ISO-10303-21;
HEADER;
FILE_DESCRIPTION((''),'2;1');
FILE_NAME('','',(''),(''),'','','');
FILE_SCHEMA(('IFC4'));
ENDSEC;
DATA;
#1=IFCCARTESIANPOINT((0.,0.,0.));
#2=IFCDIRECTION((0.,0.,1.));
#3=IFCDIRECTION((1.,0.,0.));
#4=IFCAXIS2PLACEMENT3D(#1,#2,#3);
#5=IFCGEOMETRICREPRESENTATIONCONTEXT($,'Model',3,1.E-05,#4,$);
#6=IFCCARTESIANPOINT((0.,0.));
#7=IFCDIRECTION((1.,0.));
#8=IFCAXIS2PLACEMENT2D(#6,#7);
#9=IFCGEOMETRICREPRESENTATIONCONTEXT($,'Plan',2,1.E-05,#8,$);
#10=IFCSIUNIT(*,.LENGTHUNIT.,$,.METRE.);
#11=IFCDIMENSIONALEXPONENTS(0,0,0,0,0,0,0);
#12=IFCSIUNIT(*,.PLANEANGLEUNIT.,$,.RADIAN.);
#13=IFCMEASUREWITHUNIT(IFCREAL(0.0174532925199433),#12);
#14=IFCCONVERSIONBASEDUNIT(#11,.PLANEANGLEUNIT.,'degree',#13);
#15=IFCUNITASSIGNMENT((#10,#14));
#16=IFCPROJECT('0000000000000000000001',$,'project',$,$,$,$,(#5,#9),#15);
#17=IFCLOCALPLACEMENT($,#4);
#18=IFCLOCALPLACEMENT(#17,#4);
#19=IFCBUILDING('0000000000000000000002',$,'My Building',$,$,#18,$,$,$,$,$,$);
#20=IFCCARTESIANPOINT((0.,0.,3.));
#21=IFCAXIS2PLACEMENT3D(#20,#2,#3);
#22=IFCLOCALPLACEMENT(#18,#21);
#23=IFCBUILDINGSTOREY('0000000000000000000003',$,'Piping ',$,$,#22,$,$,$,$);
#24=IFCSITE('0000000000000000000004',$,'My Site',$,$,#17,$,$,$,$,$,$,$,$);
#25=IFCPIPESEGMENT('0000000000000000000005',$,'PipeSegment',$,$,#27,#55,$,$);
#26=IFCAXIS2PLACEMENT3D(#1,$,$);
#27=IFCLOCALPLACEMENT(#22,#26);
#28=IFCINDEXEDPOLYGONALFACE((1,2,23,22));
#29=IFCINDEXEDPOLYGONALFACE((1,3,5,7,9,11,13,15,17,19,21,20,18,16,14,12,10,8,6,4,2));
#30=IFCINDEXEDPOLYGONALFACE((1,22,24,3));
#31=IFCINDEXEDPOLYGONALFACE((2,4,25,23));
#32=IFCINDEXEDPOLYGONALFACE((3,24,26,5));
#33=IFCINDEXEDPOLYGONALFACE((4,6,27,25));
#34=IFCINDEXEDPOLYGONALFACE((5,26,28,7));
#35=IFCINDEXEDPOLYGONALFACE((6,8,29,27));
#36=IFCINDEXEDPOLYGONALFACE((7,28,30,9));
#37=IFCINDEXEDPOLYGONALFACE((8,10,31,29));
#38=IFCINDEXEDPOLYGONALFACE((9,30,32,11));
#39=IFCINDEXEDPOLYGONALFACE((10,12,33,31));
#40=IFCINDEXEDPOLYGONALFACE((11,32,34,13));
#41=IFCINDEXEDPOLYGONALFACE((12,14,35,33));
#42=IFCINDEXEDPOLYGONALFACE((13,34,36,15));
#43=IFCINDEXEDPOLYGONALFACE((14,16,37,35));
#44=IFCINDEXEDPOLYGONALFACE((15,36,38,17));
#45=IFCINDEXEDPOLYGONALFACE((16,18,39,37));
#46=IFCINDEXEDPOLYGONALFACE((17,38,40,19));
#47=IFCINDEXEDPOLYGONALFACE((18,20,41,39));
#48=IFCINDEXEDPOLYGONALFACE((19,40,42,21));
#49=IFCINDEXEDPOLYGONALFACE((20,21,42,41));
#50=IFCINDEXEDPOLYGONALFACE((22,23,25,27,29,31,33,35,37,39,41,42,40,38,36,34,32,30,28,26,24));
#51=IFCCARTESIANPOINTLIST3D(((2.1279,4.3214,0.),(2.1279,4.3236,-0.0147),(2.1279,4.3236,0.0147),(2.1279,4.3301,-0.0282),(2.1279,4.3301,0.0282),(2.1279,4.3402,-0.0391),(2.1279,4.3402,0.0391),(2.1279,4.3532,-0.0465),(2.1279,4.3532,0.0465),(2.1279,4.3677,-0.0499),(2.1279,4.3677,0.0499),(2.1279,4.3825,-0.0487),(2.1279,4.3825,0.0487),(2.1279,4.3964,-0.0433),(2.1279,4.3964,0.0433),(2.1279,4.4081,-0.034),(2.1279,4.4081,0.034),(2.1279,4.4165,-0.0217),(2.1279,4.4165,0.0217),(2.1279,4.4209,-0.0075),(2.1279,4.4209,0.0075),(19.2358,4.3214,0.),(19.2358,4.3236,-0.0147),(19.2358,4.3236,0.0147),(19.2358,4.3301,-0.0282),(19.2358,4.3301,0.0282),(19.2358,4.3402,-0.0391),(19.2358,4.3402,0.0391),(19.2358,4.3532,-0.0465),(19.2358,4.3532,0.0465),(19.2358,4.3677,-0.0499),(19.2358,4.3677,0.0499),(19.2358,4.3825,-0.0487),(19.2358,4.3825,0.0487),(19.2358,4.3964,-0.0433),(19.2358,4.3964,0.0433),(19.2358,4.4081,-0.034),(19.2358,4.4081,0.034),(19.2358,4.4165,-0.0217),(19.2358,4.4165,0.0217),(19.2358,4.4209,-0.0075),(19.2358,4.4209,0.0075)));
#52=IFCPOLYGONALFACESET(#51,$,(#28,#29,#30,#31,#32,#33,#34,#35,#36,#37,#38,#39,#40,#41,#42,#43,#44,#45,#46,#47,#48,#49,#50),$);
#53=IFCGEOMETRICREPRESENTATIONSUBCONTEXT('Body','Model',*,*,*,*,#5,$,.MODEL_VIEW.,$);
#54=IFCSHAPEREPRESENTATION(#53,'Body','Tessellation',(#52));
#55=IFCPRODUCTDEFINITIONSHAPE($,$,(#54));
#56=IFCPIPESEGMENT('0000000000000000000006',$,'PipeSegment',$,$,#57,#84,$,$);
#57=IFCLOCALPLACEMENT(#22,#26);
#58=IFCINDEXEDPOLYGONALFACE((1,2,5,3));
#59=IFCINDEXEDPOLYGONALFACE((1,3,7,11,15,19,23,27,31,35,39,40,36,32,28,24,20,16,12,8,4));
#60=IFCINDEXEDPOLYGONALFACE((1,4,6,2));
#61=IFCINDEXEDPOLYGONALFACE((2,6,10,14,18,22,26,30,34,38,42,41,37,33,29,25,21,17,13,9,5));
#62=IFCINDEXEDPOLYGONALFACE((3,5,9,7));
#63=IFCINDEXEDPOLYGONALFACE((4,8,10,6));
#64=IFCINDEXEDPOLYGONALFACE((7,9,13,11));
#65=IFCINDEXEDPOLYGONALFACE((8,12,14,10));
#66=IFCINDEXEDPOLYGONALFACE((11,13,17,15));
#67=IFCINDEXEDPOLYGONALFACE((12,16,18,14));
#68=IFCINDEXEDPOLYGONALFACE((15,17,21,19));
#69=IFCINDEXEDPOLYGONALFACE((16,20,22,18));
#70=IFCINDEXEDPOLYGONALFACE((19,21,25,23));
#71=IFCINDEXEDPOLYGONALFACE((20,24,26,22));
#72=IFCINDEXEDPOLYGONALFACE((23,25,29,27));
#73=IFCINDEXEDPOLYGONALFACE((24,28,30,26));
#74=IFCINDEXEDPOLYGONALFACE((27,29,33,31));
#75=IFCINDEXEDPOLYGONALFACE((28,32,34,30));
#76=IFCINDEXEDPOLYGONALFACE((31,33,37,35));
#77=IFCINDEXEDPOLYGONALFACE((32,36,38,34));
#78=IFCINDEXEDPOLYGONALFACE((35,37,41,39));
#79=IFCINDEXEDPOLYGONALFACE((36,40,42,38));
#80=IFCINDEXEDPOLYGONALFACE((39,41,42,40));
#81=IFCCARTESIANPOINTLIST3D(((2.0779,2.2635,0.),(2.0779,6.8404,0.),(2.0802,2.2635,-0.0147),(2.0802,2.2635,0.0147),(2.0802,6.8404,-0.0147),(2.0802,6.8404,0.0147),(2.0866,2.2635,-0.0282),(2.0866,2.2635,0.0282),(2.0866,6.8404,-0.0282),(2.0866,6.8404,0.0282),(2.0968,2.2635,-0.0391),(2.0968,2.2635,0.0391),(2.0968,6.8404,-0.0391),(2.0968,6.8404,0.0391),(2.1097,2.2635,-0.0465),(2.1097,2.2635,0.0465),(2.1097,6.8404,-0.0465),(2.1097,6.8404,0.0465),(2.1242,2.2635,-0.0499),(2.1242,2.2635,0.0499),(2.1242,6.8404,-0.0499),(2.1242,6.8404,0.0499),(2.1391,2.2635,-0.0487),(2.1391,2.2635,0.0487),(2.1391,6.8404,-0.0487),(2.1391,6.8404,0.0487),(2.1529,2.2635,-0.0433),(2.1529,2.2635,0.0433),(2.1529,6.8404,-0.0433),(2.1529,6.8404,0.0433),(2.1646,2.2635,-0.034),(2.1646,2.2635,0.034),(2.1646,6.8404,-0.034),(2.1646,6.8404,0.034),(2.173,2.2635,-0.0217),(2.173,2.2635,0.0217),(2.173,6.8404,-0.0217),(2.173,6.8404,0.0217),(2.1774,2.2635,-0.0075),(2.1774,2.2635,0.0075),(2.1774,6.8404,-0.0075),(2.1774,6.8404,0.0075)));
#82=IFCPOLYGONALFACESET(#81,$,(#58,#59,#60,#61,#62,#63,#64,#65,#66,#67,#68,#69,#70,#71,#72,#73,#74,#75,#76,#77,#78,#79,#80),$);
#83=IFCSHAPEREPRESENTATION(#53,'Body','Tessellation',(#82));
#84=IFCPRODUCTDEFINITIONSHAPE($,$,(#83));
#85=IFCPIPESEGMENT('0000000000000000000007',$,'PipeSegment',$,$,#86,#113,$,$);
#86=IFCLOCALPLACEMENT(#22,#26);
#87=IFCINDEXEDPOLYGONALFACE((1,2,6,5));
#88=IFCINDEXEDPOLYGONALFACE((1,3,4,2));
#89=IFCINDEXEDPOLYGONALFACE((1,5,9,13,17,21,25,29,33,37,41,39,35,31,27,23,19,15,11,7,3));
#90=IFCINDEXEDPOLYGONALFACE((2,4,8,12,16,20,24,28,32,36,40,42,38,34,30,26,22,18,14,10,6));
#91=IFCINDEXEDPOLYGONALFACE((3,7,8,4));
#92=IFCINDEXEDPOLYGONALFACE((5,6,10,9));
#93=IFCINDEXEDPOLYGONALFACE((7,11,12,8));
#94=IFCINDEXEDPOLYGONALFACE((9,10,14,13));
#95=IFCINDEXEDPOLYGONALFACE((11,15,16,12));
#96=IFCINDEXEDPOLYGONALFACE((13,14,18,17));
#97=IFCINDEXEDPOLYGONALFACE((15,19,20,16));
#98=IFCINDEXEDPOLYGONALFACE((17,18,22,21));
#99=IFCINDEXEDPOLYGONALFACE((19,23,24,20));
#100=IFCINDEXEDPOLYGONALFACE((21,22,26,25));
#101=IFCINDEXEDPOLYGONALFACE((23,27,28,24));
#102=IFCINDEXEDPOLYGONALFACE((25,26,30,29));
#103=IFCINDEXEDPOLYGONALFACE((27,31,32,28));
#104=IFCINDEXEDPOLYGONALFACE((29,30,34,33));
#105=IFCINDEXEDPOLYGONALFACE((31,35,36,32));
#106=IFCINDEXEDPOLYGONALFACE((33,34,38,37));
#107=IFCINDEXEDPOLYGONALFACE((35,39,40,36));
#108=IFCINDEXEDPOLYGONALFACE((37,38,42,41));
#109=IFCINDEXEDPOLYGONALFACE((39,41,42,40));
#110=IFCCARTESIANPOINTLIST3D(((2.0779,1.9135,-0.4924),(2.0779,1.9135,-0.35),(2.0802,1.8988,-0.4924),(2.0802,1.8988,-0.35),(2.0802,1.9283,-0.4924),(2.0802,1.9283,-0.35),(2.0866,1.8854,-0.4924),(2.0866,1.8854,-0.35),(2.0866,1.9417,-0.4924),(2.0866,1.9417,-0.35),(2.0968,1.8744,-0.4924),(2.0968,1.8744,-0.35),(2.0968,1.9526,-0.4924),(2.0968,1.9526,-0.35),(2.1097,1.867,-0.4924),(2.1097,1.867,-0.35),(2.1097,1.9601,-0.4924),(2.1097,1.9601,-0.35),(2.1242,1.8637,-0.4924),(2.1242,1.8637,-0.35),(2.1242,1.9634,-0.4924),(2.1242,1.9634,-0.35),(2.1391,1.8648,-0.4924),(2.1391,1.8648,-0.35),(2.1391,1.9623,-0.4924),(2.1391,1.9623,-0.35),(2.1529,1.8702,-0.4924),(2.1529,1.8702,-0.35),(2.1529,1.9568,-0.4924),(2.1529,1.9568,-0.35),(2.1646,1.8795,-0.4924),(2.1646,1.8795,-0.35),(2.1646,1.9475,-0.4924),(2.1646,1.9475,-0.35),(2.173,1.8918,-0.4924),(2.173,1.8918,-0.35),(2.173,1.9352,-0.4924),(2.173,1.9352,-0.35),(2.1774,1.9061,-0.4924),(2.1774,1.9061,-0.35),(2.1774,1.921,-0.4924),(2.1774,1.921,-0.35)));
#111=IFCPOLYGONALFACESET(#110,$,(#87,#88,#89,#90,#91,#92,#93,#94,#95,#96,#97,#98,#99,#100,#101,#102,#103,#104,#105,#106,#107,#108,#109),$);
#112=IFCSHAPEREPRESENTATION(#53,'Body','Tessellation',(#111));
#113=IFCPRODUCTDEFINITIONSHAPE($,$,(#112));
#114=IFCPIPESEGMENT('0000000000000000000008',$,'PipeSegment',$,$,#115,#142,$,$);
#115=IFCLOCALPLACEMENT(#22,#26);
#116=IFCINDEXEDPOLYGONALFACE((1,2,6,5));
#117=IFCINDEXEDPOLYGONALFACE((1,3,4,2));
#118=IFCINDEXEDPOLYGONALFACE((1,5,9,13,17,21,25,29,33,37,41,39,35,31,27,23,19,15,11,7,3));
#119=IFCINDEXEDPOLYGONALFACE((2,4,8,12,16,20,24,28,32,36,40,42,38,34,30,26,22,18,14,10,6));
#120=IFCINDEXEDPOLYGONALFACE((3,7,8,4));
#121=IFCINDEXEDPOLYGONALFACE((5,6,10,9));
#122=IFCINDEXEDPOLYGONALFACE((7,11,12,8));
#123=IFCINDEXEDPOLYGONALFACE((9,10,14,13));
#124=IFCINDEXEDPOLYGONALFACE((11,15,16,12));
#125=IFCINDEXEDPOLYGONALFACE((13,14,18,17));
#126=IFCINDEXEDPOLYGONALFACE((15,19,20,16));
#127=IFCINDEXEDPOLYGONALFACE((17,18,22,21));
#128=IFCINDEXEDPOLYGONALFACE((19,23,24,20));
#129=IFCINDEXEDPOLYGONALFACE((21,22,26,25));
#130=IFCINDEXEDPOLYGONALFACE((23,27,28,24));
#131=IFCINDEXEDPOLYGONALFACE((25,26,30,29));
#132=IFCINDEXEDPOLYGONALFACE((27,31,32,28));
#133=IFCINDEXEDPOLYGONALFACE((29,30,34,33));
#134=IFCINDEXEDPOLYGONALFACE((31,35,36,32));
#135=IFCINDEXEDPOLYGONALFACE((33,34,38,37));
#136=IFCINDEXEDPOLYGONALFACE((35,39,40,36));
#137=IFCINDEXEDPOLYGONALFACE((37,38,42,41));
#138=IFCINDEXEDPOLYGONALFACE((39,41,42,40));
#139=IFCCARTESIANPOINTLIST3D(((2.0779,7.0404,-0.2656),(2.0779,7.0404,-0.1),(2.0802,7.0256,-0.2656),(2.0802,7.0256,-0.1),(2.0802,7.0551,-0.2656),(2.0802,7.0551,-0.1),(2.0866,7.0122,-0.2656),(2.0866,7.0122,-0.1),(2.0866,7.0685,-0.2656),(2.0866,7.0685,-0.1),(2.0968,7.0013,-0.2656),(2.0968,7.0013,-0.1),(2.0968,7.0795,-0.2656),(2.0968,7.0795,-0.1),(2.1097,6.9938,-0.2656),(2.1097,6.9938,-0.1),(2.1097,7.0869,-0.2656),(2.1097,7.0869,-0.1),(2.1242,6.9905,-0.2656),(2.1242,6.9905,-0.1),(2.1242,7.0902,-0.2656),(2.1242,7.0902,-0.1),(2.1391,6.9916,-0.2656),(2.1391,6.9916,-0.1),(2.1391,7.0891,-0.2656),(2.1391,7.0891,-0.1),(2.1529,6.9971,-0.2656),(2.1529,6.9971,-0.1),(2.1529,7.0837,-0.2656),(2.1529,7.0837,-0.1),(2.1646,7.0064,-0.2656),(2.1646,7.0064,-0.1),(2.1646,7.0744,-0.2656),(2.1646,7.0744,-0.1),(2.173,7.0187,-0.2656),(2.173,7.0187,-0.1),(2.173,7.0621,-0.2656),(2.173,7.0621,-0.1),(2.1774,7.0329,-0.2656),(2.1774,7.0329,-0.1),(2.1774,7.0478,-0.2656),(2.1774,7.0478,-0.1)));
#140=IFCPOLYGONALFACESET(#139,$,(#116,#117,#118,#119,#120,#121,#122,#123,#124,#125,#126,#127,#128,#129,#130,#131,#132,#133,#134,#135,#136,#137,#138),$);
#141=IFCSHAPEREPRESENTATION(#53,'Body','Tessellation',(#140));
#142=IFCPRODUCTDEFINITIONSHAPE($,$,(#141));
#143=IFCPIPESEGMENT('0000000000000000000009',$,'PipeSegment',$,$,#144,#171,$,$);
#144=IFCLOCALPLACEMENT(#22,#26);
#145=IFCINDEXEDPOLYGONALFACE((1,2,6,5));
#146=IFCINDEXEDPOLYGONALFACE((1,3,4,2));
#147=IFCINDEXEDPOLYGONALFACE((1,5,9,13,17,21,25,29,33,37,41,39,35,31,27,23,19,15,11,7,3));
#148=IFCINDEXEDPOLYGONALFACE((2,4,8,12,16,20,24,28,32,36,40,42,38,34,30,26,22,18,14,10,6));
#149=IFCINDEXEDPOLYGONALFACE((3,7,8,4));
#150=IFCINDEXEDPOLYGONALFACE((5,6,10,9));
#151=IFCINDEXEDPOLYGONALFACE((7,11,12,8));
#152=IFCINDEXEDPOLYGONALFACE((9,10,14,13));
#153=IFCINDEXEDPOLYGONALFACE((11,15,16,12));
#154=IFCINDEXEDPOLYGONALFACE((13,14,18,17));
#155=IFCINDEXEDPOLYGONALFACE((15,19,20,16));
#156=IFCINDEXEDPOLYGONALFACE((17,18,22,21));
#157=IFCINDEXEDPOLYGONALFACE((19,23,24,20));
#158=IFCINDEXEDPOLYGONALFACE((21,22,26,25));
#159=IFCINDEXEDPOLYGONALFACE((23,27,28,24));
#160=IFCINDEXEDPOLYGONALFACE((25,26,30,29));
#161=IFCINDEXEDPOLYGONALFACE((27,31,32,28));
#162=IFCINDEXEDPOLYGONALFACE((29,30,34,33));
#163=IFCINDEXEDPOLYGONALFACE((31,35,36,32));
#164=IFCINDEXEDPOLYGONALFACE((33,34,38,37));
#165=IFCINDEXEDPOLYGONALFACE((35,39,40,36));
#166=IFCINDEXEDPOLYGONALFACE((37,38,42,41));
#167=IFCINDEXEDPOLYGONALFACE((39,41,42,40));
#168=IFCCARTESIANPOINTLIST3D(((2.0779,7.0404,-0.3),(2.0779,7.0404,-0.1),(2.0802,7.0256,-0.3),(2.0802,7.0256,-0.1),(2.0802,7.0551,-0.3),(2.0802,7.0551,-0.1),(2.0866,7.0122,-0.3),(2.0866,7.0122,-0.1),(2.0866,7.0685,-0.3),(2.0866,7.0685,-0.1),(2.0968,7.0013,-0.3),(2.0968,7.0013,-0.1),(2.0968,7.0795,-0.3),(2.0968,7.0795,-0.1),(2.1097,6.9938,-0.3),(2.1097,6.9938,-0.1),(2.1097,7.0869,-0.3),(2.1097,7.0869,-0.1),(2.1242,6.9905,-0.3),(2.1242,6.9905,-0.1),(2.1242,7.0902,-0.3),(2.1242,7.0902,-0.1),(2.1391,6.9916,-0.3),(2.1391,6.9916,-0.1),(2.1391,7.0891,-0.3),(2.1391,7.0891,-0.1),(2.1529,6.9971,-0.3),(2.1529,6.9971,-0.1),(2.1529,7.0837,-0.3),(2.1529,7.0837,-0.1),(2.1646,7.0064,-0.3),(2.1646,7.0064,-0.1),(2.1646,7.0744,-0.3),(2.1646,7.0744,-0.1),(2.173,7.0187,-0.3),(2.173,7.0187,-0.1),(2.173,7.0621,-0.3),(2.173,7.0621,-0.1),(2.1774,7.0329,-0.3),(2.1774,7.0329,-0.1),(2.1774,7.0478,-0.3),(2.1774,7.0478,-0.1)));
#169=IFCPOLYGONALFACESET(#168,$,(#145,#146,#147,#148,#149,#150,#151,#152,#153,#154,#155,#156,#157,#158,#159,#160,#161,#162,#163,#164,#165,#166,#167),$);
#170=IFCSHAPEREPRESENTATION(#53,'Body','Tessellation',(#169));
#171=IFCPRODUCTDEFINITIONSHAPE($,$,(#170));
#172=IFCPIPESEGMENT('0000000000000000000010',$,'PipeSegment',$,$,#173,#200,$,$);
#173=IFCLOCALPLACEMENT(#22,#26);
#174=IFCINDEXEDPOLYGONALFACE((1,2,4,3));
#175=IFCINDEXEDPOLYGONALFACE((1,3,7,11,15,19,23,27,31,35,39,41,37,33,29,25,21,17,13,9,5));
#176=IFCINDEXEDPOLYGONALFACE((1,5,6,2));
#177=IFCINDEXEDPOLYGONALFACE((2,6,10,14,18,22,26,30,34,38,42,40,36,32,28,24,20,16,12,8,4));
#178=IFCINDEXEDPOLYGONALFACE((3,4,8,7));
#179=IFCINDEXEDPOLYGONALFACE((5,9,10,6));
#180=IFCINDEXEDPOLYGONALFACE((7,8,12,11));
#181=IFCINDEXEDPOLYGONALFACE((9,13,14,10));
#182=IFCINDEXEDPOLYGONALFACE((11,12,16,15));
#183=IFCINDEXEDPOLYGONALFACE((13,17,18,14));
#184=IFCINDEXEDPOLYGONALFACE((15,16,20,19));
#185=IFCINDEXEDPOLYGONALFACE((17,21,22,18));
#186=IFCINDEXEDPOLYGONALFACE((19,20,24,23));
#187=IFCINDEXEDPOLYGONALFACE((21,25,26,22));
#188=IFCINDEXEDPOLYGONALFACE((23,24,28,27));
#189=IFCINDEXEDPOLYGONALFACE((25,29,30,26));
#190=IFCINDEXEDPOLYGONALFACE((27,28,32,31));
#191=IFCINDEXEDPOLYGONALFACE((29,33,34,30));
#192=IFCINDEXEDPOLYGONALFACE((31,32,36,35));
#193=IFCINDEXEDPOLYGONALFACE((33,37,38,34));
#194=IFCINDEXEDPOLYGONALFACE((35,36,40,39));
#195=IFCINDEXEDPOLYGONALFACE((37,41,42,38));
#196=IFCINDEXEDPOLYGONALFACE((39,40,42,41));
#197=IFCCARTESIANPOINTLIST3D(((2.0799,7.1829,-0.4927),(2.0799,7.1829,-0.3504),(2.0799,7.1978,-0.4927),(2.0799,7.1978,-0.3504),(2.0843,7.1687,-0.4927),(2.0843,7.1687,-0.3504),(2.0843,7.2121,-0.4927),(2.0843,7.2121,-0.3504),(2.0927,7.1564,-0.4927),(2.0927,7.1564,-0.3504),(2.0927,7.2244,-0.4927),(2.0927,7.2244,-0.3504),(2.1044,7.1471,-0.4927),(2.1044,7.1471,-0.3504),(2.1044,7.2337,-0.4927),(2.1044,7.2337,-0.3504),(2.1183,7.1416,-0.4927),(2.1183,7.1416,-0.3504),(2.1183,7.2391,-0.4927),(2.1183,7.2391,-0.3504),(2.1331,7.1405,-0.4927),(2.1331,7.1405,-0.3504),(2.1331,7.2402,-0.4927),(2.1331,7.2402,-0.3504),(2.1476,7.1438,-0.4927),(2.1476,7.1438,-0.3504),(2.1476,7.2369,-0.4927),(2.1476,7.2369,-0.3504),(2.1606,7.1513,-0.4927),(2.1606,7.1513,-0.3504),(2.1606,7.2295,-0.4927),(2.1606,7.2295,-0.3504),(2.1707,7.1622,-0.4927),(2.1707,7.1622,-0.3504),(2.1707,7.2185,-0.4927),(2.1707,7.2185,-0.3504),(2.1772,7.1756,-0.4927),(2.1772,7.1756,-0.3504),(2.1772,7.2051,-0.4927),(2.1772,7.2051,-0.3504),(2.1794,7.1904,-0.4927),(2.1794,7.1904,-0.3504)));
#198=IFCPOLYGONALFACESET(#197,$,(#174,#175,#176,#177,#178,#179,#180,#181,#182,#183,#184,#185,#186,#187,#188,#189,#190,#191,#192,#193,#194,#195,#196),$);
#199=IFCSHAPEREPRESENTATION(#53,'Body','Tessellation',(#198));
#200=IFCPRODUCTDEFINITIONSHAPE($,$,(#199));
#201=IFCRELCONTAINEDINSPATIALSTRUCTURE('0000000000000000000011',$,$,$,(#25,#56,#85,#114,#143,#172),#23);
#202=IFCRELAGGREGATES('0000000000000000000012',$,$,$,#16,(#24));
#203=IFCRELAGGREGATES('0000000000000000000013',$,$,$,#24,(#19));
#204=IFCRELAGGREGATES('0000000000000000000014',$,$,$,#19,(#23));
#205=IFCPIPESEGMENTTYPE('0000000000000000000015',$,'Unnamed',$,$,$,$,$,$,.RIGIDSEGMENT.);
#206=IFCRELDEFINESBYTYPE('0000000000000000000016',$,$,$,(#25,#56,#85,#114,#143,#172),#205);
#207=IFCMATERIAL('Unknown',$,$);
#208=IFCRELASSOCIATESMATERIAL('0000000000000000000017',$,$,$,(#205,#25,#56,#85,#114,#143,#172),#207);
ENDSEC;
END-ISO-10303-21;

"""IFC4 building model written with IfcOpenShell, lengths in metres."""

from ifc_helpers import new_model, entity, si_unit, converted_unit, frame, origin_with_axes, origin_2d_with_axis, place, context, subcontext, project, spatial, circle, extrude, material, material_profile, profile_set, profile_usage, type_object, element, save


model = new_model("IFC4")

# Units and contexts
model_context = context("Model", 3, precision=1e-05, world=origin_with_axes())
plan_context = context("Plan", 2, precision=1e-05, world=origin_2d_with_axis())
body_context = subcontext(model_context, "Body", "Model", "MODEL_VIEW")
ifc_project = project(units=[si_unit("LENGTHUNIT", "METRE"), converted_unit("PLANEANGLEUNIT", "degree", entity("IfcReal", 0.0174532925199433), si_unit("PLANEANGLEUNIT", "RADIAN"), dimensions=[0, 0, 0, 0, 0, 0, 0])], contexts=[model_context, plan_context])

# Site, building, storey
site_placement = place(None, origin_with_axes())
site = spatial("IfcSite", under=ifc_project, at=site_placement, Name="My Site")
building_placement = place(site_placement, origin_with_axes())
building = spatial("IfcBuilding", under=site, at=building_placement, Name="My Building")
storey_placement = place(building_placement, frame((0.0, 0.0, 3.0), z_axis=(0.0, 0.0, 1.0), x_axis=(1.0, 0.0, 0.0)))
storey = spatial("IfcBuildingStorey", under=building, at=storey_placement, Name="Piping ")

# Pipe segments
ifc_material = material(Name="Unknown")
ifc_material_profile = material_profile(ifc_material, circle(Radius=0.05))
ifc_profile_set = profile_set([ifc_material_profile])
ifc_profile_usage_1 = profile_usage(ifc_profile_set, cardinal=5)
pipe_segment_type = type_object("IfcPipeSegmentType", Name="Unnamed", PredefinedType="RIGIDSEGMENT", material=ifc_profile_set)
pipe_segment_1_placement = place(storey_placement, frame((19.2358, 4.3714, 0.0), z_axis=(-1.0, 0.0, 0.0), x_axis=(0.0, -1.0, 0.0)))
element("IfcPipeSegment", 1, at=pipe_segment_1_placement, inside=storey, type_object=pipe_segment_type, material=ifc_profile_usage_1, Name="PipeSegment", context=body_context, shape_type="SweptSolid", body=[
    extrude(circle(Radius=0.05), origin_with_axes(), (0.0, 0.0, 1.0), 17.1079),
])
ifc_profile_usage_2 = profile_usage(ifc_profile_set, cardinal=5)
pipe_segment_2_placement = place(storey_placement, frame((2.1279, 2.2635, 0.0), z_axis=(0.0, 1.0, 0.0), x_axis=(-1.0, 0.0, 0.0)))
element("IfcPipeSegment", 2, at=pipe_segment_2_placement, inside=storey, type_object=pipe_segment_type, material=ifc_profile_usage_2, Name="PipeSegment", context=body_context, shape_type="SweptSolid", body=[
    extrude(circle(Radius=0.05), origin_with_axes(), (0.0, 0.0, 1.0), 4.5768),
])
ifc_profile_usage_3 = profile_usage(ifc_profile_set, cardinal=5)
pipe_segment_3_placement = place(storey_placement, frame((2.1279, 1.9135, -0.35), z_axis=(0.0, 0.0, -1.0), x_axis=(-1.0, 0.0, 0.0)))
element("IfcPipeSegment", 3, at=pipe_segment_3_placement, inside=storey, type_object=pipe_segment_type, material=ifc_profile_usage_3, Name="PipeSegment", context=body_context, shape_type="SweptSolid", body=[
    extrude(circle(Radius=0.05), origin_with_axes(), (0.0, 0.0, 1.0), 0.1424),
])
ifc_profile_usage_4 = profile_usage(ifc_profile_set, cardinal=5)
pipe_segment_4_placement = place(storey_placement, frame((2.1279, 7.0404, -0.1), z_axis=(0.0, 0.0, -1.0), x_axis=(-1.0, 0.0, 0.0)))
element("IfcPipeSegment", 4, at=pipe_segment_4_placement, inside=storey, type_object=pipe_segment_type, material=ifc_profile_usage_4, Name="PipeSegment", context=body_context, shape_type="SweptSolid", body=[
    extrude(circle(Radius=0.05), origin_with_axes(), (0.0, 0.0, 1.0), 0.1656),
])
ifc_profile_usage_5 = profile_usage(ifc_profile_set, cardinal=5)
pipe_segment_5_placement = place(storey_placement, frame((2.1279, 7.0404, -0.1), z_axis=(0.0, 0.0, -1.0), x_axis=(-1.0, 0.0, 0.0)))
element("IfcPipeSegment", 5, at=pipe_segment_5_placement, inside=storey, type_object=pipe_segment_type, material=ifc_profile_usage_5, Name="PipeSegment", context=body_context, shape_type="SweptSolid", body=[
    extrude(circle(Radius=0.05), origin_with_axes(), (0.0, 0.0, 1.0), 0.2),
])
ifc_profile_usage_6 = profile_usage(ifc_profile_set, cardinal=5)
pipe_segment_6_placement = place(storey_placement, frame((2.1294, 7.1904, -0.3504), z_axis=(0.0, 0.0, -1.0), x_axis=(1.0, 0.0, 0.0)))
element("IfcPipeSegment", 6, at=pipe_segment_6_placement, inside=storey, type_object=pipe_segment_type, material=ifc_profile_usage_6, Name="PipeSegment", context=body_context, shape_type="SweptSolid", body=[
    extrude(circle(Radius=0.05), origin_with_axes(), (0.0, 0.0, 1.0), 0.1424),
])

save(model, "model.ifc")
